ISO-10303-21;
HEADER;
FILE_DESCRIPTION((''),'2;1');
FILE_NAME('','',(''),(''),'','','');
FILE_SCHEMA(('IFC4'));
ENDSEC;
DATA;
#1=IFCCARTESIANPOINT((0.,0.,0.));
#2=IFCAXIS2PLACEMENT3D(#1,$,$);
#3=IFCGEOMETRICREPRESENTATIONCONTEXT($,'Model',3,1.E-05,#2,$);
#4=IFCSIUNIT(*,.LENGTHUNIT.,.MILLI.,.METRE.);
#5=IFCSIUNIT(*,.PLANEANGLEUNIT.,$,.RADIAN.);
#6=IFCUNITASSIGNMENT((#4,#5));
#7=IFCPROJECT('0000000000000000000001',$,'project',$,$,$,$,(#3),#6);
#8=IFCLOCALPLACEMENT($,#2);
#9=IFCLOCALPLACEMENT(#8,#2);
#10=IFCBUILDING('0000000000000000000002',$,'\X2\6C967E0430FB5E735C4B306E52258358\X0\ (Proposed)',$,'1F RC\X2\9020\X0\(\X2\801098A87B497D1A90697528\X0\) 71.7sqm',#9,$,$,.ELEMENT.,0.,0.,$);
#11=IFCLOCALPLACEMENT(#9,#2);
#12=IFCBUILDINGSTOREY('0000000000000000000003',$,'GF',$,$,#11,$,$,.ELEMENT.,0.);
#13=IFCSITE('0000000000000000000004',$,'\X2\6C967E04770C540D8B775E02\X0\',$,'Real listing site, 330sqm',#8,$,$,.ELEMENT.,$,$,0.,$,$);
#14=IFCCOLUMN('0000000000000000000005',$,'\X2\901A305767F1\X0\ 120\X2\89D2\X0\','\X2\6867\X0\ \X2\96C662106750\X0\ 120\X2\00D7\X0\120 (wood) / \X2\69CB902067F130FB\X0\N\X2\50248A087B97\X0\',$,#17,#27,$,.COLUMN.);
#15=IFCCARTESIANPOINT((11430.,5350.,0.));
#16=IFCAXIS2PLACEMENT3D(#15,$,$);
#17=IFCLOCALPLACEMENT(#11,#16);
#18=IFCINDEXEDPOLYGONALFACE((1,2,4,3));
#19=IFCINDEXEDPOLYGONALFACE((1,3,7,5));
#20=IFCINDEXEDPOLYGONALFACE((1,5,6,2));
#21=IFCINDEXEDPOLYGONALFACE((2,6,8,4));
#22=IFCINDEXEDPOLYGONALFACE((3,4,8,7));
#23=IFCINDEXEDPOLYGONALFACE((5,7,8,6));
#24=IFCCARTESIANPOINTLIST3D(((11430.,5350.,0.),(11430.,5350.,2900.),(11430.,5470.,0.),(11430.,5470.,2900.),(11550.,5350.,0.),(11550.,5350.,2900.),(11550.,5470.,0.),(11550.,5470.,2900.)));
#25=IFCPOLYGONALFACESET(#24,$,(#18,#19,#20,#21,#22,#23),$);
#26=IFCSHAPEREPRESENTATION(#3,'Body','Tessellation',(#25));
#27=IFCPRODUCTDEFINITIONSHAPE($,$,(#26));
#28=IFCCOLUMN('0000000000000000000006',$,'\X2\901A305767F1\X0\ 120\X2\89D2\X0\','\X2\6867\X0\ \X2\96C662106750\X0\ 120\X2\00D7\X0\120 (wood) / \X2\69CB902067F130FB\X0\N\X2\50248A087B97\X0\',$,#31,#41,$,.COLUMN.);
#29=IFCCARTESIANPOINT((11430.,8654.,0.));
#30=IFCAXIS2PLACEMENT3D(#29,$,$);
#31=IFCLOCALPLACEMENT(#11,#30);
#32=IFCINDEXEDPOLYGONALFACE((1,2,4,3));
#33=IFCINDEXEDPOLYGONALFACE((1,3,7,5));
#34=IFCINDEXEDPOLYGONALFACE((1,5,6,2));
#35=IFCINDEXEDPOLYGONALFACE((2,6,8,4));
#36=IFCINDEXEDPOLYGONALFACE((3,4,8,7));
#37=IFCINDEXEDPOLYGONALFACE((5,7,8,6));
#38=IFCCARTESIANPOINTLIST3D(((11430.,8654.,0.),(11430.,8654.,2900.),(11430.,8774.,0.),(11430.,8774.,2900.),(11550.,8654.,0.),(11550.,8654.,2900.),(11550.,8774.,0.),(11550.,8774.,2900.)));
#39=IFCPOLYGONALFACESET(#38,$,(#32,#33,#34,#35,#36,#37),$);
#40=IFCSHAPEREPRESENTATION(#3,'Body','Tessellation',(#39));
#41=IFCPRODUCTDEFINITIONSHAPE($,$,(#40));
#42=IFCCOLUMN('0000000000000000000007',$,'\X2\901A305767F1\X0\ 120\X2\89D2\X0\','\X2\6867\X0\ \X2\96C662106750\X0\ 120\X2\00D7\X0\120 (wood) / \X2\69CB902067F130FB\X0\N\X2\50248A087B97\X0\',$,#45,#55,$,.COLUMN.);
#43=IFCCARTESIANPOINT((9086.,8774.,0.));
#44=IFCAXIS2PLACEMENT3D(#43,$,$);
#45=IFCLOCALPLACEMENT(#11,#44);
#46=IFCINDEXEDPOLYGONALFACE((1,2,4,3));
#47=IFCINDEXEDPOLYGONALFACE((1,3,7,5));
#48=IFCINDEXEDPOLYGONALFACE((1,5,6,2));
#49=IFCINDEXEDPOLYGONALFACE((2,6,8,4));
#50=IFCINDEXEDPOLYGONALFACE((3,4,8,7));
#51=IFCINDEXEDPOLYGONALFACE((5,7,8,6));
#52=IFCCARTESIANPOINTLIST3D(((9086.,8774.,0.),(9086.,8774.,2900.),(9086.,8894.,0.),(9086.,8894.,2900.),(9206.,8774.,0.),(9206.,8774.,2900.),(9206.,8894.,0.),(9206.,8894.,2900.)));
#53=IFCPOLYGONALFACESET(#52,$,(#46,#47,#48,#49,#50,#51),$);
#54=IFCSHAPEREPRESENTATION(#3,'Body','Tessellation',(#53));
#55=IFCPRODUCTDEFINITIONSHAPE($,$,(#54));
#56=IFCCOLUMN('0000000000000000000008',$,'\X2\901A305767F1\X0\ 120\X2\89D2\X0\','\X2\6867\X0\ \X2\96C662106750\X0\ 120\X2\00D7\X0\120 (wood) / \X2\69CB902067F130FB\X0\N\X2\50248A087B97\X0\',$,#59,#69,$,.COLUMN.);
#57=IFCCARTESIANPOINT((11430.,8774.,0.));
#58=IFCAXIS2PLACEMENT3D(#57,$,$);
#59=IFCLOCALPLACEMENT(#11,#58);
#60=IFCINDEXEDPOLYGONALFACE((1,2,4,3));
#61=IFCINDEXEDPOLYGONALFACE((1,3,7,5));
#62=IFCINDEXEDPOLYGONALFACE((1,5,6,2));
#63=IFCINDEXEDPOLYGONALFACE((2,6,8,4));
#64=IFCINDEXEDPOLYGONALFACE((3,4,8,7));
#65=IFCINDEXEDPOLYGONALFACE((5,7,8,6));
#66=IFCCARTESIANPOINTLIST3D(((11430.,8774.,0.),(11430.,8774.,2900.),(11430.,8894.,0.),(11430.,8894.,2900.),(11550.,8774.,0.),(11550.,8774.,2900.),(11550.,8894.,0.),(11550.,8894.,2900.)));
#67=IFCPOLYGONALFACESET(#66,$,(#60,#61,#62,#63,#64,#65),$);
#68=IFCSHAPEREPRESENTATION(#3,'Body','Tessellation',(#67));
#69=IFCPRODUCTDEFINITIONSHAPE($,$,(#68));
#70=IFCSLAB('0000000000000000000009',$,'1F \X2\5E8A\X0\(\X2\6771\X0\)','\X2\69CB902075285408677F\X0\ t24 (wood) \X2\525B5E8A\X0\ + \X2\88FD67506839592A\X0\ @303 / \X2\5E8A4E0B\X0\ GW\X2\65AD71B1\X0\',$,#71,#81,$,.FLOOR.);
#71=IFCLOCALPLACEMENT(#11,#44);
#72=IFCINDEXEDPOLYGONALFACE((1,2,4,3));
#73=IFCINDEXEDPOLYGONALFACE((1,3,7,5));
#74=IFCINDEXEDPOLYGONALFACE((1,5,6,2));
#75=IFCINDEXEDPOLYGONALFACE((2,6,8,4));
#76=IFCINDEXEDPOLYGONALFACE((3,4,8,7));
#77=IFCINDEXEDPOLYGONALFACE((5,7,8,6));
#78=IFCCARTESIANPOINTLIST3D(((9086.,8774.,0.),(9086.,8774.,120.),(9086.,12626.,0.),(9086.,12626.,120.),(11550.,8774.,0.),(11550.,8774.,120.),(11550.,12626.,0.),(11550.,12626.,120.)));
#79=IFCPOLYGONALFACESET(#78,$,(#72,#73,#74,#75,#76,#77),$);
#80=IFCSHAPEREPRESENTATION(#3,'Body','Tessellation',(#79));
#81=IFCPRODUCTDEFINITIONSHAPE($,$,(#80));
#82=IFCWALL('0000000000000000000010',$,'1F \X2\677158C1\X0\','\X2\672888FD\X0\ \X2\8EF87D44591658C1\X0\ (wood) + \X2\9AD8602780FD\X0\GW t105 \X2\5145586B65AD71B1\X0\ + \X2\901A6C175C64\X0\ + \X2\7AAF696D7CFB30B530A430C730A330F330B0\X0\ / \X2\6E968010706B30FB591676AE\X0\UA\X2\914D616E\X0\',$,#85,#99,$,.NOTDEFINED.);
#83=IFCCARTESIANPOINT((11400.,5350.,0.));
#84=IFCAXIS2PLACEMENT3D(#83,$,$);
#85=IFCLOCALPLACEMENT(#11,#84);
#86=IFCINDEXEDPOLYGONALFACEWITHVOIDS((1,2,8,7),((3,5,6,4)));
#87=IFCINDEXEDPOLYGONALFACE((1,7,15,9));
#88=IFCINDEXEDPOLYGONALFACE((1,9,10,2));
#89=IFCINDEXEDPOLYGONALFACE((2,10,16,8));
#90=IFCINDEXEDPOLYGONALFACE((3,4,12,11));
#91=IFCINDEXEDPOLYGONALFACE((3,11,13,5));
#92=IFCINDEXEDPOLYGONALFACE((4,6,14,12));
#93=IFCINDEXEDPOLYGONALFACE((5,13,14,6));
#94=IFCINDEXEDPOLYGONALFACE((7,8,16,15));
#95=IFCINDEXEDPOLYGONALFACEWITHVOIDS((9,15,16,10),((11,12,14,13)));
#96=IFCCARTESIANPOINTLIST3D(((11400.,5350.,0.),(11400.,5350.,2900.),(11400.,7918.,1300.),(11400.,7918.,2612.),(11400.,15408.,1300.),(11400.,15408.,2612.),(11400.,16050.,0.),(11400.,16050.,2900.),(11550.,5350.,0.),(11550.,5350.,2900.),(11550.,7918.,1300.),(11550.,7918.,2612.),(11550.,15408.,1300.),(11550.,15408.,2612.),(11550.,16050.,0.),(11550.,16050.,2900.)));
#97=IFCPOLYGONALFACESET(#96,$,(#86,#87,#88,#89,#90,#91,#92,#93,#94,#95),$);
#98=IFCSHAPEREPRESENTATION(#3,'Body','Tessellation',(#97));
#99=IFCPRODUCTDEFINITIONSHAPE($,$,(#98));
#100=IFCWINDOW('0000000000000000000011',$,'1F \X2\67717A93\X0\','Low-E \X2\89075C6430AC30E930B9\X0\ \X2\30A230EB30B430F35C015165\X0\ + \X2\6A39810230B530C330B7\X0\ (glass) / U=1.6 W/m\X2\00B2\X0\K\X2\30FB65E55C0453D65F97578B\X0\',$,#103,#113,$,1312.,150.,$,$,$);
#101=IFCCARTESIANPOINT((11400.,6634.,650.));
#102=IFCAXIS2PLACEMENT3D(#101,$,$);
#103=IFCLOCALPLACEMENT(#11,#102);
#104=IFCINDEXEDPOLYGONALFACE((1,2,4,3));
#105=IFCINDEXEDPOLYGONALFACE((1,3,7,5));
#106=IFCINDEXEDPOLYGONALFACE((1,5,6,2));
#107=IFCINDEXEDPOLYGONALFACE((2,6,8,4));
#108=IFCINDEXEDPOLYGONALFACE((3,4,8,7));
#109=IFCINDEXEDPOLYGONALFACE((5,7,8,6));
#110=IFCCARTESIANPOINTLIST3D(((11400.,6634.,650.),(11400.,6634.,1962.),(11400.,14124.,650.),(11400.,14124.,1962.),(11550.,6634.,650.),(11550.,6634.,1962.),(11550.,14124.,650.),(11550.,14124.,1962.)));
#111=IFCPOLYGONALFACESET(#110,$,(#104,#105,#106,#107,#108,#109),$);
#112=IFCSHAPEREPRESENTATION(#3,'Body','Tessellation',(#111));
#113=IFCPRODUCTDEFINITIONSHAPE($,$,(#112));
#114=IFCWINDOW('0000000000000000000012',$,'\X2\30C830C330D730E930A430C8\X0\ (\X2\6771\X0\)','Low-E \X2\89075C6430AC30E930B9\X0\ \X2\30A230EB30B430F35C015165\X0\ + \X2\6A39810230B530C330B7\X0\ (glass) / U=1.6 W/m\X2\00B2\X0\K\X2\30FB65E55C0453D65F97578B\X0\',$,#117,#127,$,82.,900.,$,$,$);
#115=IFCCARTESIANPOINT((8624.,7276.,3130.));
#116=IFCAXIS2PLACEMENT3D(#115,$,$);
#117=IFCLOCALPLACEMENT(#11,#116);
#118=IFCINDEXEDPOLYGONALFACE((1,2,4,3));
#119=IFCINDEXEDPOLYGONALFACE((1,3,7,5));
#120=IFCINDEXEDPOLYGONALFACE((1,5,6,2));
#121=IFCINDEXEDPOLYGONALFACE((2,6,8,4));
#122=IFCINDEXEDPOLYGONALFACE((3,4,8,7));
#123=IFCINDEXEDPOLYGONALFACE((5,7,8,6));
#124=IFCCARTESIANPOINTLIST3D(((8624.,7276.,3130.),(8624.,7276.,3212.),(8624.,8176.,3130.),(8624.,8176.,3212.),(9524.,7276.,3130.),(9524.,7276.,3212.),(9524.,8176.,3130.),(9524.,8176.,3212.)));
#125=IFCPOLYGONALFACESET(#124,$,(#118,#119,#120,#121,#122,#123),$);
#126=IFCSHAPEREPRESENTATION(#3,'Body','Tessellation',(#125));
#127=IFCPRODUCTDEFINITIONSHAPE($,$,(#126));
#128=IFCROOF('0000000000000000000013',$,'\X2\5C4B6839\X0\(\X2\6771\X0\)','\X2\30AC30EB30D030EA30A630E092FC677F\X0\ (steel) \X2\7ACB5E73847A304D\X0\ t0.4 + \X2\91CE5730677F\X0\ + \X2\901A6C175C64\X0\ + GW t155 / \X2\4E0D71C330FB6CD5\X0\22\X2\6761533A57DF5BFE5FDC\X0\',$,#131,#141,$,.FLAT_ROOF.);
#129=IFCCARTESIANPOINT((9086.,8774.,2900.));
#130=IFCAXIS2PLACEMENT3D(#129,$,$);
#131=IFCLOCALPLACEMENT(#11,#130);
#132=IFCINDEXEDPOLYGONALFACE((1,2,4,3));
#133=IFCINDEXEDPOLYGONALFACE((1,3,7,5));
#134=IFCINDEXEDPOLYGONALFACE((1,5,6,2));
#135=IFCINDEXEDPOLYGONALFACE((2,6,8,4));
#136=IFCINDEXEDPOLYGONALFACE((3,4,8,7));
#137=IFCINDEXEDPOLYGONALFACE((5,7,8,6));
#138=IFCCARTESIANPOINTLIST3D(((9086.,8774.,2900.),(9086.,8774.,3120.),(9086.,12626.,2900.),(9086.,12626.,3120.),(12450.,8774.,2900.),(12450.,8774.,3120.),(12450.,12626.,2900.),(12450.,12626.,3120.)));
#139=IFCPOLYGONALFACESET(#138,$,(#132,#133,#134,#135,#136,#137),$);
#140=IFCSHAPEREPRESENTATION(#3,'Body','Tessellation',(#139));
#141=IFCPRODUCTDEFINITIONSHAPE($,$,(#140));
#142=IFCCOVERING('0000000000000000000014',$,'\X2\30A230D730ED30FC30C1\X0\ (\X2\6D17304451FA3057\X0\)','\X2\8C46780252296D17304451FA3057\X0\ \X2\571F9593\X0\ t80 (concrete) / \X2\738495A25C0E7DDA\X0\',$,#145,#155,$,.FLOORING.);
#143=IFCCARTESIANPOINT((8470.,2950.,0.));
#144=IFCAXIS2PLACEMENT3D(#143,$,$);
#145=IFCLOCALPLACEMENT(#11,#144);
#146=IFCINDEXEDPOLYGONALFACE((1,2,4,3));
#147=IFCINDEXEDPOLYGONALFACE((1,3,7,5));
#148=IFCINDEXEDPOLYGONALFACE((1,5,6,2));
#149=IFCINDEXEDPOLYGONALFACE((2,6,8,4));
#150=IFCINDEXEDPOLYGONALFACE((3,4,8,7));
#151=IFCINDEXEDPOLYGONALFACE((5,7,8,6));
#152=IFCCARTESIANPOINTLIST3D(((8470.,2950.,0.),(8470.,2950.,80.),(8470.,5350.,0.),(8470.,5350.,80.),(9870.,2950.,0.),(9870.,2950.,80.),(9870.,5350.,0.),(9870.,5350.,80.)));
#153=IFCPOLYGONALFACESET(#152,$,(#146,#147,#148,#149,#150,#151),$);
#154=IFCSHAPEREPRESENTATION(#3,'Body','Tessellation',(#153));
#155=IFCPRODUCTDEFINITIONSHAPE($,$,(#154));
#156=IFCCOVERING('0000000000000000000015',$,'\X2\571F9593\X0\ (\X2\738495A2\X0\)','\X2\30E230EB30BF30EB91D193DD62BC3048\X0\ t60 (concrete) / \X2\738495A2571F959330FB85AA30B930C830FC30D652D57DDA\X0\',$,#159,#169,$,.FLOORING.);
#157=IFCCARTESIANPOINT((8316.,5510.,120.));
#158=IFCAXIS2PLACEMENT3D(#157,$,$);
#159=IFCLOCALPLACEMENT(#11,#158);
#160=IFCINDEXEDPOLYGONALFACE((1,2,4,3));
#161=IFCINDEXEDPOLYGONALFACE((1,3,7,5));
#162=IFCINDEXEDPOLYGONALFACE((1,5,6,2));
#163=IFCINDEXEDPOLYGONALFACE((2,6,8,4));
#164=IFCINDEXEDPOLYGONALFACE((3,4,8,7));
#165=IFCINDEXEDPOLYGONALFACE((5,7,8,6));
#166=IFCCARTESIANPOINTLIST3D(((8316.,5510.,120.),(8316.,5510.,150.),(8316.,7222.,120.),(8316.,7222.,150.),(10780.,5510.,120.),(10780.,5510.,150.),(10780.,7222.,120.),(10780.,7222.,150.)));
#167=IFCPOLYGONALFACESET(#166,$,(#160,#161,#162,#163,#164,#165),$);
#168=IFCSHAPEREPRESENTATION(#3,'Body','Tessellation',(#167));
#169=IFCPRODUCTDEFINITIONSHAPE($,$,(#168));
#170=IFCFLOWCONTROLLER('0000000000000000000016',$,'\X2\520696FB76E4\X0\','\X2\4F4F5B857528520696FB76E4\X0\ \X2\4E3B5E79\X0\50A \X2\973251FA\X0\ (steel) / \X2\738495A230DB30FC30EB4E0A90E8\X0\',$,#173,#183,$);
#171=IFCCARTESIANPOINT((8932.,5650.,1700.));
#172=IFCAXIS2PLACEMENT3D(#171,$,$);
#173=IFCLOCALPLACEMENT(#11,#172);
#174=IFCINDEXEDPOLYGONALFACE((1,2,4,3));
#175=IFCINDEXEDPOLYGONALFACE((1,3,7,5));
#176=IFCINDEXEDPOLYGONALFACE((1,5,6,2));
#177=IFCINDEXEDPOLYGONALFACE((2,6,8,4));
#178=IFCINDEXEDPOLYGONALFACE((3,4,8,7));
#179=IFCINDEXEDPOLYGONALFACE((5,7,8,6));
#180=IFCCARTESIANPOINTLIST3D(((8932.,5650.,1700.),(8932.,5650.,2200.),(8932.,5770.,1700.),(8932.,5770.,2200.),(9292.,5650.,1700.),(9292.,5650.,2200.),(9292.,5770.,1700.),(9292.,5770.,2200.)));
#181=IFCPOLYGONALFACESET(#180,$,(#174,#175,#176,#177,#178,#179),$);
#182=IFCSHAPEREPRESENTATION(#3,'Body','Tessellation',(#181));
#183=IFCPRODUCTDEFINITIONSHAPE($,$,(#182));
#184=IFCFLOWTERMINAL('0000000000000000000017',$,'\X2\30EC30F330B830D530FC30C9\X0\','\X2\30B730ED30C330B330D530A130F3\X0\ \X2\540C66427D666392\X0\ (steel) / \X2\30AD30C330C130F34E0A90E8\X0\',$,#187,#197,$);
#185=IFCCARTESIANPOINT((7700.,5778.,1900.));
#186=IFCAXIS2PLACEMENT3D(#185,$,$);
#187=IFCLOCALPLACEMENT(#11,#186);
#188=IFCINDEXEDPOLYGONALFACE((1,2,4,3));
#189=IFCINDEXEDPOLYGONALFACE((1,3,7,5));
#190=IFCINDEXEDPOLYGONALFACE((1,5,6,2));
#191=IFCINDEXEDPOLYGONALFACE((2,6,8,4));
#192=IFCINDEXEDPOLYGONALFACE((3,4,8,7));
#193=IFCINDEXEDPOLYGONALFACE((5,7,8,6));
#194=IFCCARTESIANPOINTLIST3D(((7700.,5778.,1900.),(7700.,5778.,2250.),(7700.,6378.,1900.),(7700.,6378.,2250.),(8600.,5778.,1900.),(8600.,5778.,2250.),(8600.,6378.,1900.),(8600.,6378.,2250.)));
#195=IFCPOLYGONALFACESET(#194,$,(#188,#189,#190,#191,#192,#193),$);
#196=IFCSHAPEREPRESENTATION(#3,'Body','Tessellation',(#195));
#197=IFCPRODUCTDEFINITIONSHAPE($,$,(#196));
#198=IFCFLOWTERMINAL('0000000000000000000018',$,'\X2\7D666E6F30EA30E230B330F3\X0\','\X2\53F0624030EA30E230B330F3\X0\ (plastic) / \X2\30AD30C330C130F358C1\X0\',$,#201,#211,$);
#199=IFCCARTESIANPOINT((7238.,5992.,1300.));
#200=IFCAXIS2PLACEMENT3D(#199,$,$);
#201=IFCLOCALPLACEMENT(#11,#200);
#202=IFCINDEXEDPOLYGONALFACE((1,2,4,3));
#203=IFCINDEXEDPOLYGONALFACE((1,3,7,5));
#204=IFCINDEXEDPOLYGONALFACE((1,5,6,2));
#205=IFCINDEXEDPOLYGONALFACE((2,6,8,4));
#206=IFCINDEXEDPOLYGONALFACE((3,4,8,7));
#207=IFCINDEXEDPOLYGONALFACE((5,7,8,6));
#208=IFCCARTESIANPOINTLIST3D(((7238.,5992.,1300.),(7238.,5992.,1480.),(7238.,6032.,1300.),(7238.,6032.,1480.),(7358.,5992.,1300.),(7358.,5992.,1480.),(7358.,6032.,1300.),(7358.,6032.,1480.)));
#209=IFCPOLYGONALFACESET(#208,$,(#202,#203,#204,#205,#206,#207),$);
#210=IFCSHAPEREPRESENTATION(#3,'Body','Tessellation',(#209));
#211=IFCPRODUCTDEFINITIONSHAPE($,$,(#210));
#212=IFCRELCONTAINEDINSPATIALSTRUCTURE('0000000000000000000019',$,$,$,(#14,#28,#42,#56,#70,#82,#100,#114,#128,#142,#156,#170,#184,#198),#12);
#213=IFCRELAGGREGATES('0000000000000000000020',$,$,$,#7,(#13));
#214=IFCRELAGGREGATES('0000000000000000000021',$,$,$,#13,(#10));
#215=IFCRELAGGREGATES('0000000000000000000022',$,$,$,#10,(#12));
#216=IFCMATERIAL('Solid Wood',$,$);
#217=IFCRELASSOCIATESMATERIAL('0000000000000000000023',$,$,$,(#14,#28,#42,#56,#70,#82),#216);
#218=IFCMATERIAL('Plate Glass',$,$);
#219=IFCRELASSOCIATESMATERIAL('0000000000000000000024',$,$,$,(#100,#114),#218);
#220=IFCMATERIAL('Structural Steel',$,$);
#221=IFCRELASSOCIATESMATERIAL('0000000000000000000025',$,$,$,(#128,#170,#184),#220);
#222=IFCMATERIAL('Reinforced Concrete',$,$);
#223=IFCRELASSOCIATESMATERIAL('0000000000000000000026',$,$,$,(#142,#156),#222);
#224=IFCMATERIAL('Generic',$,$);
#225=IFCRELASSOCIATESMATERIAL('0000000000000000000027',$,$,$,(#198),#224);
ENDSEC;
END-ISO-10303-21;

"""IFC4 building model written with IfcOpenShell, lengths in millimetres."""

from ifc_helpers import new_model, si_unit, frame, frame_2d, origin, place, context, project, spatial, rectangle, extrude, material, element, fill, save


model = new_model("IFC4")

# Units and contexts
model_context = context("Model", 3, precision=1e-05, world=origin())
ifc_project = project(units=[si_unit("LENGTHUNIT", "METRE", prefix="MILLI"), si_unit("PLANEANGLEUNIT", "RADIAN")], contexts=[model_context])

# Site, building, storey
site_placement = place(None, origin())
site = spatial("IfcSite", under=ifc_project, at=site_placement, Name="沖縄県名護市", ObjectType="Real listing site, 330sqm", CompositionType="ELEMENT", RefElevation=0.0)
building_placement = place(site_placement, origin())
building = spatial("IfcBuilding", under=site, at=building_placement, Name="沖縄・平屋の別荘 (Proposed)", ObjectType="1F RC造(耐風等級適用) 71.7sqm", CompositionType="ELEMENT", ElevationOfRefHeight=0.0, ElevationOfTerrain=0.0)
storey_placement = place(building_placement, origin())
storey = spatial("IfcBuildingStorey", under=building, at=storey_placement, Name="GF", CompositionType="ELEMENT", Elevation=0.0)

# Columns
ifc_material_1 = material(Name="Solid Wood")
column_1_placement = place(storey_placement, frame((11430.0, 5350.0, 0.0)))
element("IfcColumn", 1, at=column_1_placement, inside=storey, material=ifc_material_1, Name="通し柱 120角", Description="桧 集成材 120×120 (wood) / 構造柱・N値計算", PredefinedType="COLUMN", context=model_context, shape_type="SweptSolid", body=[
    extrude(rectangle(XDim=120.0, YDim=120.0, at=frame_2d((60.0, 60.0))), frame((11430.0, 5350.0, 0.0)), (0.0, 0.0, 1.0), 2900.0),
])
column_2_placement = place(storey_placement, frame((11430.0, 8654.0, 0.0)))
element("IfcColumn", 2, at=column_2_placement, inside=storey, material=ifc_material_1, Name="通し柱 120角", Description="桧 集成材 120×120 (wood) / 構造柱・N値計算", PredefinedType="COLUMN", context=model_context, shape_type="SweptSolid", body=[
    extrude(rectangle(XDim=120.0, YDim=120.0, at=frame_2d((60.0, 60.0))), frame((11430.0, 8654.0, 0.0)), (0.0, 0.0, 1.0), 2900.0),
])
column_3_placement = place(storey_placement, frame((9086.0, 8774.0, 0.0)))
element("IfcColumn", 3, at=column_3_placement, inside=storey, material=ifc_material_1, Name="通し柱 120角", Description="桧 集成材 120×120 (wood) / 構造柱・N値計算", PredefinedType="COLUMN", context=model_context, shape_type="SweptSolid", body=[
    extrude(rectangle(XDim=120.0, YDim=120.0, at=frame_2d((60.0, 60.0))), frame((9086.0, 8774.0, 0.0)), (0.0, 0.0, 1.0), 2900.0),
])
column_4_placement = place(storey_placement, frame((11430.0, 8774.0, 0.0)))
element("IfcColumn", 4, at=column_4_placement, inside=storey, material=ifc_material_1, Name="通し柱 120角", Description="桧 集成材 120×120 (wood) / 構造柱・N値計算", PredefinedType="COLUMN", context=model_context, shape_type="SweptSolid", body=[
    extrude(rectangle(XDim=120.0, YDim=120.0, at=frame_2d((60.0, 60.0))), frame((11430.0, 8774.0, 0.0)), (0.0, 0.0, 1.0), 2900.0),
])

# Slab
slab_placement = place(storey_placement, frame((9086.0, 8774.0, 0.0)))
element("IfcSlab", 5, at=slab_placement, inside=storey, material=ifc_material_1, Name="1F 床(東)", Description="構造用合板 t24 (wood) 剛床 + 製材根太 @303 / 床下 GW断熱", PredefinedType="FLOOR", context=model_context, shape_type="SweptSolid", body=[
    extrude(rectangle(XDim=2464.0, YDim=3852.0, at=frame_2d((1232.0, 1926.0))), frame((9086.0, 8774.0, 0.0)), (0.0, 0.0, 1.0), 120.0),
])

# Wall, opening, window
wall_1_placement = place(storey_placement, frame((11400.0, 5350.0, 0.0)))
wall_1 = element("IfcWall", 6, at=wall_1_placement, inside=storey, material=ifc_material_1, Name="1F 東壁", Description="木製 軸組外壁 (wood) + 高性能GW t105 充填断熱 + 通気層 + 窯業系サイディング / 準耐火・外皮UA配慮", PredefinedType="NOTDEFINED", context=model_context, shape_type="SweptSolid", body=[
    extrude(rectangle(XDim=150.0, YDim=10700.0, at=frame_2d((75.0, 5350.0))), frame((11400.0, 5350.0, 0.0)), (0.0, 0.0, 1.0), 2900.0),
])
opening_placement = place(storey_placement, frame((11400.0, 6634.0, 650.0)))
opening = element("IfcOpeningElement", 7, at=opening_placement, cuts=wall_1, PredefinedType="NOTDEFINED", context=model_context, shape_type="SweptSolid", body=[
    extrude(rectangle(XDim=150.0, YDim=7490.0, at=frame_2d((75.0, 3745.0))), frame((11400.0, 6634.0, 650.0)), (0.0, 0.0, 1.0), 1312.0),
])
ifc_material_2 = material(Name="Plate Glass")
window_1_placement = place(storey_placement, frame((11400.0, 6634.0, 650.0)))
window_1 = element("IfcWindow", 8, at=window_1_placement, inside=storey, material=ifc_material_2, Name="1F 東窓", Description="Low-E 複層ガラス アルゴン封入 + 樹脂サッシ (glass) / U=1.6 W/m²K・日射取得型", OverallHeight=1312.0, OverallWidth=150.0, context=model_context, shape_type="SweptSolid", body=[
    extrude(rectangle(XDim=150.0, YDim=7490.0, at=frame_2d((75.0, 3745.0))), frame((11400.0, 6634.0, 650.0)), (0.0, 0.0, 1.0), 1312.0),
])
fill(opening, window_1)

# Window
window_2_placement = place(storey_placement, frame((8624.0, 7276.0, 3130.0)))
element("IfcWindow", 9, at=window_2_placement, inside=storey, material=ifc_material_2, Name="トップライト (東)", Description="Low-E 複層ガラス アルゴン封入 + 樹脂サッシ (glass) / U=1.6 W/m²K・日射取得型", OverallHeight=82.0, OverallWidth=900.0, context=model_context, shape_type="SweptSolid", body=[
    extrude(rectangle(XDim=900.0, YDim=900.0, at=frame_2d((450.0, 450.0))), frame((8624.0, 7276.0, 3130.0)), (0.0, 0.0, 1.0), 82.0),
])

# Roof
ifc_material_3 = material(Name="Structural Steel")
roof_placement = place(storey_placement, frame((9086.0, 8774.0, 2900.0)))
element("IfcRoof", 10, at=roof_placement, inside=storey, material=ifc_material_3, Name="屋根(東)", Description="ガルバリウム鋼板 (steel) 立平葺き t0.4 + 野地板 + 通気層 + GW t155 / 不燃・法22条区域対応", PredefinedType="FLAT_ROOF", context=model_context, shape_type="SweptSolid", body=[
    extrude(rectangle(XDim=3364.0, YDim=3852.0, at=frame_2d((1682.0, 1926.0))), frame((9086.0, 8774.0, 2900.0)), (0.0, 0.0, 1.0), 220.0),
])

# Coverings
ifc_material_4 = material(Name="Reinforced Concrete")
covering_1_placement = place(storey_placement, frame((8470.0, 2950.0, 0.0)))
element("IfcCovering", 11, at=covering_1_placement, inside=storey, material=ifc_material_4, Name="アプローチ (洗い出し)", Description="豆砂利洗い出し 土間 t80 (concrete) / 玄関導線", PredefinedType="FLOORING", context=model_context, shape_type="SweptSolid", body=[
    extrude(rectangle(XDim=1400.0, YDim=2400.0, at=frame_2d((700.0, 1200.0))), frame((8470.0, 2950.0, 0.0)), (0.0, 0.0, 1.0), 80.0),
])
covering_2_placement = place(storey_placement, frame((8316.0, 5510.0, 120.0)))
element("IfcCovering", 12, at=covering_2_placement, inside=storey, material=ifc_material_4, Name="土間 (玄関)", Description="モルタル金鏝押え t60 (concrete) / 玄関土間・薪ストーブ動線", PredefinedType="FLOORING", context=model_context, shape_type="SweptSolid", body=[
    extrude(rectangle(XDim=2464.0, YDim=1712.0, at=frame_2d((1232.0, 856.0))), frame((8316.0, 5510.0, 120.0)), (0.0, 0.0, 1.0), 30.0),
])

# Flow controller
flow_controller_placement = place(storey_placement, frame((8932.0, 5650.0, 1700.0)))
element("IfcFlowController", 13, at=flow_controller_placement, inside=storey, material=ifc_material_3, Name="分電盤", Description="住宅用分電盤 主幹50A 露出 (steel) / 玄関ホール上部", context=model_context, shape_type="SweptSolid", body=[
    extrude(rectangle(XDim=360.0, YDim=120.0, at=frame_2d((180.0, 60.0))), frame((8932.0, 5650.0, 1700.0)), (0.0, 0.0, 1.0), 500.0),
])

# Flow terminals
flow_terminal_1_placement = place(storey_placement, frame((7700.0, 5778.0, 1900.0)))
element("IfcFlowTerminal", 14, at=flow_terminal_1_placement, inside=storey, material=ifc_material_3, Name="レンジフード", Description="シロッコファン 同時給排 (steel) / キッチン上部", context=model_context, shape_type="SweptSolid", body=[
    extrude(rectangle(XDim=900.0, YDim=600.0, at=frame_2d((450.0, 300.0))), frame((7700.0, 5778.0, 1900.0)), (0.0, 0.0, 1.0), 350.0),
])
ifc_material_5 = material(Name="Generic")
flow_terminal_2_placement = place(storey_placement, frame((7238.0, 5992.0, 1300.0)))
element("IfcFlowTerminal", 15, at=flow_terminal_2_placement, inside=storey, material=ifc_material_5, Name="給湯リモコン", Description="台所リモコン (plastic) / キッチン壁", context=model_context, shape_type="SweptSolid", body=[
    extrude(rectangle(XDim=120.0, YDim=40.0, at=frame_2d((60.0, 20.0))), frame((7238.0, 5992.0, 1300.0)), (0.0, 0.0, 1.0), 180.0),
])

save(model, "model.ifc")
